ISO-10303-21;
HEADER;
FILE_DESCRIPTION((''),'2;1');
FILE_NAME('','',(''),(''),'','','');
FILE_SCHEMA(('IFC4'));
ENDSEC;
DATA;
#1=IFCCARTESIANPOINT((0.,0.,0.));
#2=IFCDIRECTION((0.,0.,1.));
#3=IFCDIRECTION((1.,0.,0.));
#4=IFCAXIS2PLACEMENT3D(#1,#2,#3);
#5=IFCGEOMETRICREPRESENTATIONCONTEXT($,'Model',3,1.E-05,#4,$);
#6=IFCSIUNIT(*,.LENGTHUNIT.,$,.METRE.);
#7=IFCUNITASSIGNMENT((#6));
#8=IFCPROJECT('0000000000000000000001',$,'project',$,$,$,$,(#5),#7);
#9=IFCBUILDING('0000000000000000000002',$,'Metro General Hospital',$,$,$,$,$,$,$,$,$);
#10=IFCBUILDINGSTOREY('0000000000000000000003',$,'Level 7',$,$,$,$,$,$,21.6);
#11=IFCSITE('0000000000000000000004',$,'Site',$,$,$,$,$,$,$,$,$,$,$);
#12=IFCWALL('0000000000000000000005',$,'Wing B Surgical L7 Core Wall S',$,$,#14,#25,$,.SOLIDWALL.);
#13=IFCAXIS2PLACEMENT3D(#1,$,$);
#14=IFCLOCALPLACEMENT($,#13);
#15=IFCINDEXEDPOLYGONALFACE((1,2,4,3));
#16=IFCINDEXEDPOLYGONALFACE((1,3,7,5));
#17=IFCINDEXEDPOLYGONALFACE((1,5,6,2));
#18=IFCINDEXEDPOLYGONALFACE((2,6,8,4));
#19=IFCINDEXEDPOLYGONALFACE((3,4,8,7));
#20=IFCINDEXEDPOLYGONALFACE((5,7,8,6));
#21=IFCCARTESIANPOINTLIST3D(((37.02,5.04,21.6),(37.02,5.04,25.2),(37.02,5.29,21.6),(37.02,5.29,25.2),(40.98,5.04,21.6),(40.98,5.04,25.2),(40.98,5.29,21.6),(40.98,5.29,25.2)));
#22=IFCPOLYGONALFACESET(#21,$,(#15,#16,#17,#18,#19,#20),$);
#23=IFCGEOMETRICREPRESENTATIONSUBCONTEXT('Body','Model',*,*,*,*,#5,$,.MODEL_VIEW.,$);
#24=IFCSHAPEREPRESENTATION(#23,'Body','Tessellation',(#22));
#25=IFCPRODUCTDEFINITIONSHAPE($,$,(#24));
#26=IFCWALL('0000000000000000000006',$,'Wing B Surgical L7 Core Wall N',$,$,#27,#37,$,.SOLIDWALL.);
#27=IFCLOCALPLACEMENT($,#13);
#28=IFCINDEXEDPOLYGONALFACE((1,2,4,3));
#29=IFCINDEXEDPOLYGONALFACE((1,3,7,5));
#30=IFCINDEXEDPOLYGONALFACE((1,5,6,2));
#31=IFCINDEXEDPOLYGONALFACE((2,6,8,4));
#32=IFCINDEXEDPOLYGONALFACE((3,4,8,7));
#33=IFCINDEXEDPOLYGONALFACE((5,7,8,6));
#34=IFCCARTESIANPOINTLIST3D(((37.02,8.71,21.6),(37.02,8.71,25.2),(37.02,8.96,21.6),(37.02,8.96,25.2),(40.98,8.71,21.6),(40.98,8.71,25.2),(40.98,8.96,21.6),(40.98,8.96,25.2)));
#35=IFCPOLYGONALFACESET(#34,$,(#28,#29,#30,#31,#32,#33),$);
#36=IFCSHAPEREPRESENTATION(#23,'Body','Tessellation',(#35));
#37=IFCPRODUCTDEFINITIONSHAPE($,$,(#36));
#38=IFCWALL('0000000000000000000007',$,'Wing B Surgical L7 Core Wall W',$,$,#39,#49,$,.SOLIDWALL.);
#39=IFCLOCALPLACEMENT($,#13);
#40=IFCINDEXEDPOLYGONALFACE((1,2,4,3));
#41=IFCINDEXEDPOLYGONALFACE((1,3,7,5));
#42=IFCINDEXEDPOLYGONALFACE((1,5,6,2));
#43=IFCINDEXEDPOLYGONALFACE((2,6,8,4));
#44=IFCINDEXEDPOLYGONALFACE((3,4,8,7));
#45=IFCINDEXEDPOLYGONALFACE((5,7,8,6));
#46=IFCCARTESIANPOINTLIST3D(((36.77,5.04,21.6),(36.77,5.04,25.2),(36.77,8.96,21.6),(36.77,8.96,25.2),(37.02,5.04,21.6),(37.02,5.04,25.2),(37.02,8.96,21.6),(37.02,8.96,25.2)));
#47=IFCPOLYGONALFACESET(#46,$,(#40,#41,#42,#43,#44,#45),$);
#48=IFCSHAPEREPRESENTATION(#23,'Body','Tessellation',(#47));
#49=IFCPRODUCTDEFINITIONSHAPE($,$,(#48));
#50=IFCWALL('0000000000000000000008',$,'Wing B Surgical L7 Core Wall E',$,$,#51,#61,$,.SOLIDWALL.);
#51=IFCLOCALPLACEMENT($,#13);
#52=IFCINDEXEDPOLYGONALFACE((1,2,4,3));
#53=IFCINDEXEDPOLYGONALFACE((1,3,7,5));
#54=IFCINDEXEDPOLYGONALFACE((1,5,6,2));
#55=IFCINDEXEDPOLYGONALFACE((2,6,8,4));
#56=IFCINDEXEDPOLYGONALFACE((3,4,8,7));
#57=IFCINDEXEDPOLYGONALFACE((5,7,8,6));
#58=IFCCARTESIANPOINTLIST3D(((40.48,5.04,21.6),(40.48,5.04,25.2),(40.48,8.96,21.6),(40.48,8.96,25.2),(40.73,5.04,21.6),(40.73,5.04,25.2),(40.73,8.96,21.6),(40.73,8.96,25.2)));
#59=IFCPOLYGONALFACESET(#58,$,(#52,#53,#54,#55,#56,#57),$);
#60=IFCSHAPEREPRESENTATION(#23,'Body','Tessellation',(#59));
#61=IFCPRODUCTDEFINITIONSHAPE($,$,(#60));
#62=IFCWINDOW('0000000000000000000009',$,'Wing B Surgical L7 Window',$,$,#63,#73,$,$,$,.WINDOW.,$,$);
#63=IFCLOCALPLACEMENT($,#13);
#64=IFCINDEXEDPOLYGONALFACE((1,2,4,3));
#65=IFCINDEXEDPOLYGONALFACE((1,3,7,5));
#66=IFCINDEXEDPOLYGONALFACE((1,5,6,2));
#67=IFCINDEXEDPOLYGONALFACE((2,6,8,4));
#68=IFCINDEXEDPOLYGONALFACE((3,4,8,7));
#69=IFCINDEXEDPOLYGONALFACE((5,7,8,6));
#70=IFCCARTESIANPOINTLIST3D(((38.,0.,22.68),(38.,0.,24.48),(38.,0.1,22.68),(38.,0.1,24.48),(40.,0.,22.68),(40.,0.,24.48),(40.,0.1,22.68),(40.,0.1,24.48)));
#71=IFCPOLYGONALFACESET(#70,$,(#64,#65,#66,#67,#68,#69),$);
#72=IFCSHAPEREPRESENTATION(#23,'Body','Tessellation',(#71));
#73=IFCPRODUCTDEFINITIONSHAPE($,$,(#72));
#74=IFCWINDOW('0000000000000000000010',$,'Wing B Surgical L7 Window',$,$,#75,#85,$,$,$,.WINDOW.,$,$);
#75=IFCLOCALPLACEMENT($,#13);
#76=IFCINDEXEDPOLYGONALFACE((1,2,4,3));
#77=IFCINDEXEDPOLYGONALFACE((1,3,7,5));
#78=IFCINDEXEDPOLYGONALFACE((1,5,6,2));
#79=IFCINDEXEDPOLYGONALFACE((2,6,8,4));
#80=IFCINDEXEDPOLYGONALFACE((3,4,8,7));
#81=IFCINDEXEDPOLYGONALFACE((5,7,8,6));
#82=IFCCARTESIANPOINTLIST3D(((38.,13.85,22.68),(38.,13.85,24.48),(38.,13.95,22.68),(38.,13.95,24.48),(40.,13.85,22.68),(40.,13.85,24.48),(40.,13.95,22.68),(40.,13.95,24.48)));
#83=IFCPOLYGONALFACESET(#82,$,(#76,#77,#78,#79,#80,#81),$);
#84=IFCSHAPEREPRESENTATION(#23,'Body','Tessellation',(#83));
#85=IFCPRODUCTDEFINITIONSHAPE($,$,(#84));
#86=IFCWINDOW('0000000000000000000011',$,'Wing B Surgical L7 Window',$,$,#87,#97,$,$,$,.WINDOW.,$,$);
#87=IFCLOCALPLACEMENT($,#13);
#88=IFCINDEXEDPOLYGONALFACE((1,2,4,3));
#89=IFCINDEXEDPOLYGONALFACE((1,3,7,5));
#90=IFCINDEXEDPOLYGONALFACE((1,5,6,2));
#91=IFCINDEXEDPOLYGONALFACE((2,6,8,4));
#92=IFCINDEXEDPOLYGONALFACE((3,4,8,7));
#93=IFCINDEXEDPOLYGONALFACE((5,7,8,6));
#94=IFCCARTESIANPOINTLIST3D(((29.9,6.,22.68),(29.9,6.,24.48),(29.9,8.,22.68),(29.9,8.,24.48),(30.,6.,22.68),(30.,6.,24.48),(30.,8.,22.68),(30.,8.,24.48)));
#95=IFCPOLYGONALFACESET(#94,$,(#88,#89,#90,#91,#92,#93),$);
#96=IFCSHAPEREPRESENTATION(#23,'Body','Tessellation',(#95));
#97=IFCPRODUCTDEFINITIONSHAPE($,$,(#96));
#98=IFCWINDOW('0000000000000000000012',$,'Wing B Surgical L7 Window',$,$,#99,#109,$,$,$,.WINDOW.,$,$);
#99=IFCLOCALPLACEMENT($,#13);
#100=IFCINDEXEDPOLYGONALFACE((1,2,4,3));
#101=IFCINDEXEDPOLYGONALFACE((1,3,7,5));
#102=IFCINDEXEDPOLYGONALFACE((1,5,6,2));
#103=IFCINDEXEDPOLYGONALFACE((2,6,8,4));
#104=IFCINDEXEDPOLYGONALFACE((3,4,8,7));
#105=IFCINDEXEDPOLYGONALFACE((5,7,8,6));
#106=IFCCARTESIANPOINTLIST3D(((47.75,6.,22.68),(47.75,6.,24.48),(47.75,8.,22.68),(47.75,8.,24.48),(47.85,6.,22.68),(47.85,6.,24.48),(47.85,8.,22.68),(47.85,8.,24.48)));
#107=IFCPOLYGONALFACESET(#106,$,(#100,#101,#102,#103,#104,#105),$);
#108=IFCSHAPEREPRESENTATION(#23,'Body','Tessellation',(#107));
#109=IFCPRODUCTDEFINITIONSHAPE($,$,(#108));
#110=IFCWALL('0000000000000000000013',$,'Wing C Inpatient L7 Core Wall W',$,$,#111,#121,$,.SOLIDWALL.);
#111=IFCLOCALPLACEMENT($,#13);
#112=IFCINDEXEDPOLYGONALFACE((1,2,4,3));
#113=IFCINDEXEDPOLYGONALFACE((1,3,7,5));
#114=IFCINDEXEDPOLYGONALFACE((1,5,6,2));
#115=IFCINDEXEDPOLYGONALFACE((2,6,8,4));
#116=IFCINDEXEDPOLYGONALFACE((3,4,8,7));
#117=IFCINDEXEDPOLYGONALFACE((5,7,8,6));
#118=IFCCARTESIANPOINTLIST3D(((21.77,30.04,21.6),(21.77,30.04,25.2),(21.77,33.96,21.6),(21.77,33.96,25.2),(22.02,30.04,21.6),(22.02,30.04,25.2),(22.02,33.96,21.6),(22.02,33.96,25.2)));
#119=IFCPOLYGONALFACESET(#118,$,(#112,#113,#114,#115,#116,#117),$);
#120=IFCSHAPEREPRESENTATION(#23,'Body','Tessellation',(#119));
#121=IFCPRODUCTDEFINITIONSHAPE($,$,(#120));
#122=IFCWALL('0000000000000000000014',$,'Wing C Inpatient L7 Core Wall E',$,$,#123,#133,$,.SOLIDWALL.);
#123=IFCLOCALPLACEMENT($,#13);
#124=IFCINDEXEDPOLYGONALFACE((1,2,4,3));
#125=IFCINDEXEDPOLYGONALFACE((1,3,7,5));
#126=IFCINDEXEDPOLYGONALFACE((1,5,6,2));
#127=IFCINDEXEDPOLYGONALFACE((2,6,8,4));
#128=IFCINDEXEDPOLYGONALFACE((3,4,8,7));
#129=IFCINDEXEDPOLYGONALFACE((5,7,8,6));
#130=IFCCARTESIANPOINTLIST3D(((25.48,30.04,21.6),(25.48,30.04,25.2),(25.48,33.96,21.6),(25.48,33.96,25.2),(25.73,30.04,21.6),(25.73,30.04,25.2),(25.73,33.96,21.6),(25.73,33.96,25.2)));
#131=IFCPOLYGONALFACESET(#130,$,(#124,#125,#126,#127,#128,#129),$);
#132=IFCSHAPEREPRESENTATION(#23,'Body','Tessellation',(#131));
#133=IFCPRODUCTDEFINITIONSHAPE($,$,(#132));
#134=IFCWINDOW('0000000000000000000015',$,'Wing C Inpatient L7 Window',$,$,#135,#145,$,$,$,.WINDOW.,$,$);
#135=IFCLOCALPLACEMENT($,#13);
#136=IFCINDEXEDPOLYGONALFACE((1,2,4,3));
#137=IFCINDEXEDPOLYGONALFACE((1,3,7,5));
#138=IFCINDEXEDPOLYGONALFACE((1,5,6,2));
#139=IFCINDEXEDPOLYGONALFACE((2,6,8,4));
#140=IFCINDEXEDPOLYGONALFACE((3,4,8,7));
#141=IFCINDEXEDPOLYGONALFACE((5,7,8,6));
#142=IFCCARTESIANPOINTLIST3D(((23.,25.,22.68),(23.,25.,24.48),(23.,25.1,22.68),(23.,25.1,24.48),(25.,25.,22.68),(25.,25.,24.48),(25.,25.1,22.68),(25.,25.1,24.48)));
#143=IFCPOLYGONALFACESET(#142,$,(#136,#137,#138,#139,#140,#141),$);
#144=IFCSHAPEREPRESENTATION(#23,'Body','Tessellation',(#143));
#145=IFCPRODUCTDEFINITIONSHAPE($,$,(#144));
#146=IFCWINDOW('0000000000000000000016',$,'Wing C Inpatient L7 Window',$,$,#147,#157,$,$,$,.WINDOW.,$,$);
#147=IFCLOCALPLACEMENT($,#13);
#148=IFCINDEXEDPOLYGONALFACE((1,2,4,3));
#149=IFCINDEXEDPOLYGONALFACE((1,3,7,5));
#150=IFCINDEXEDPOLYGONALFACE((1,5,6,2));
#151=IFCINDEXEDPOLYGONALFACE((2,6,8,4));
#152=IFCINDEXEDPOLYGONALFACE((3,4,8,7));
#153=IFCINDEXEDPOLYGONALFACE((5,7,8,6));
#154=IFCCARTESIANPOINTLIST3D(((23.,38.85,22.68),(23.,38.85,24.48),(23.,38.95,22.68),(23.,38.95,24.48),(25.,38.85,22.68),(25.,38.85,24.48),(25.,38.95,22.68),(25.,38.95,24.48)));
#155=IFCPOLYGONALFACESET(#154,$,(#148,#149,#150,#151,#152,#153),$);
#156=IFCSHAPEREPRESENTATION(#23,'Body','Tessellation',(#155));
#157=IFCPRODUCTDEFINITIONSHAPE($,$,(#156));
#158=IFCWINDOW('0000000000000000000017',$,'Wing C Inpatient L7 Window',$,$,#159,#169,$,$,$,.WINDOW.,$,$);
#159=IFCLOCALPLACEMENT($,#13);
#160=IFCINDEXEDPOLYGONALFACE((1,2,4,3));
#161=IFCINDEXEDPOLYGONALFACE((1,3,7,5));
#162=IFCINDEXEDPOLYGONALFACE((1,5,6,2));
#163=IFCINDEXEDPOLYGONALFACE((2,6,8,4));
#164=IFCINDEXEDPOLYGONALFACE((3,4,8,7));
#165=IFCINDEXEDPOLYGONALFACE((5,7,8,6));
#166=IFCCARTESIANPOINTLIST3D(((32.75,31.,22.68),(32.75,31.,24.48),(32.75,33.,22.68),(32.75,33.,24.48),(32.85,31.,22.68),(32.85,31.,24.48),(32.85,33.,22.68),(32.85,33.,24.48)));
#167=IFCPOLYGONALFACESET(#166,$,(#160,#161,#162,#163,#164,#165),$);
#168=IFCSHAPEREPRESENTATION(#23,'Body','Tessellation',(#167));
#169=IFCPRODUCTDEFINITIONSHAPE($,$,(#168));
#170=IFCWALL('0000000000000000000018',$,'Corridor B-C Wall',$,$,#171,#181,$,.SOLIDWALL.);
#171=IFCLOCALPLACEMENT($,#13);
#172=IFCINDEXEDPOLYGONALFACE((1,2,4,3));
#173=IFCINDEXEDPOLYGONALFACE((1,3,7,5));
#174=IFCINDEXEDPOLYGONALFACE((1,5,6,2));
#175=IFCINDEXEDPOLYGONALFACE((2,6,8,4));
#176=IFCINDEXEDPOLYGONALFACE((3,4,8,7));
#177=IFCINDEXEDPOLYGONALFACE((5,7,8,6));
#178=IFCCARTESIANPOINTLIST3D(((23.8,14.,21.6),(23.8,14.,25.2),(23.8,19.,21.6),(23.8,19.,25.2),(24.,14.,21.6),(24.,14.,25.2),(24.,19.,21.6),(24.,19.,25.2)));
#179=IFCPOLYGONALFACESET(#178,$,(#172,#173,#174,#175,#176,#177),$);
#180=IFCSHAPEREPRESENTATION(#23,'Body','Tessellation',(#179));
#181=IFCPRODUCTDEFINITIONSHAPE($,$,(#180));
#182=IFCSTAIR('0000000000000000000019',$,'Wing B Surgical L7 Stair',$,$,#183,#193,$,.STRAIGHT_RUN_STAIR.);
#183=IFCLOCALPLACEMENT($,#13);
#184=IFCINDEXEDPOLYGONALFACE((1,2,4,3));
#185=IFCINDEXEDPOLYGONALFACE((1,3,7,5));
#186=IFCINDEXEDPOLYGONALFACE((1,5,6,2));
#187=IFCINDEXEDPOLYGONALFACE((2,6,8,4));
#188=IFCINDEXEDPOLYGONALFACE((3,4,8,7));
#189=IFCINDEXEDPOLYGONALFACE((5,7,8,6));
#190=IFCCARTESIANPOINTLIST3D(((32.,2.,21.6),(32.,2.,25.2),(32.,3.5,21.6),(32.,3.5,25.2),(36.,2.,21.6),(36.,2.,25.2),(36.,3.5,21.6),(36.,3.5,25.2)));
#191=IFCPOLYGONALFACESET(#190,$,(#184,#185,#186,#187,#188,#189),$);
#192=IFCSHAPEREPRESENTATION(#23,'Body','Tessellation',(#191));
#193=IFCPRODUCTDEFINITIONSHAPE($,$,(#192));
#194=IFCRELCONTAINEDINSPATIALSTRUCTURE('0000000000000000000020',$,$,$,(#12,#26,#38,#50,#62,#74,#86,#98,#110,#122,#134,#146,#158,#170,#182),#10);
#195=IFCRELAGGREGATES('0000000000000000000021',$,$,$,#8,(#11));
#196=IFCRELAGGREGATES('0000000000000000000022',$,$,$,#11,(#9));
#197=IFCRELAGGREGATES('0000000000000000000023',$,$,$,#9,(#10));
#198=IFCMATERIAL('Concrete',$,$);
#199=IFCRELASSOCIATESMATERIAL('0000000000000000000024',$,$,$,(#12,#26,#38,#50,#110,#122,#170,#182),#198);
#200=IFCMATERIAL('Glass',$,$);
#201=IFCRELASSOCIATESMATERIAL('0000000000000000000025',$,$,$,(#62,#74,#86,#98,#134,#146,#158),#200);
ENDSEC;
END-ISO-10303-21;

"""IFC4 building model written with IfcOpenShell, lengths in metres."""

from ifc_helpers import new_model, si_unit, frame, origin_with_axes, place, context, subcontext, project, spatial, line, indexed_curve, outline, extrude, material, element, save


model = new_model("IFC4")

# Units and contexts
model_context = context("Model", 3, precision=1e-05, world=origin_with_axes())
body_context = subcontext(model_context, "Body", "Model", "MODEL_VIEW")
ifc_project = project(units=[si_unit("LENGTHUNIT", "METRE")], contexts=[model_context])

# Site, building, storey
site = spatial("IfcSite", under=ifc_project, Name="Site")
building = spatial("IfcBuilding", under=site, Name="Metro General Hospital")
storey = spatial("IfcBuildingStorey", under=building, Name="Level 7", Elevation=21.6)

# Shared definitions
ifc_material_1 = material(Name="Concrete")

# Walls
for number, where, z_axis, x_axis, name in (
    (1, (37.02, 5.04, 21.6), (0.0, 0.0, 1.0), (1.0, 0.0, 0.0), "Wing B Surgical L7 Core Wall S"),
    (2, (37.02, 8.71, 21.6), (0.0, 0.0, 1.0), (1.0, 0.0, 0.0), "Wing B Surgical L7 Core Wall N"),
):
    element("IfcWall", number, at=place(None, frame(where, z_axis=z_axis, x_axis=x_axis)), inside=storey, material=ifc_material_1, Name=name, PredefinedType="SOLIDWALL", context=body_context, shape_type="SweptSolid", body=[
        extrude(outline(indexed_curve([(0.0, 0.0), (3.96, 0.0), (3.96, 0.25), (0.0, 0.25)], segments=[line(1, 2, 3, 4, 1)])), origin_with_axes(), (0.0, 0.0, 1.0), 3.6),
    ])
for number, where, z_axis, x_axis, name in (
    (3, (37.02, 5.04, 21.6), (0.0, 0.0, 1.0), (0.0, 1.0, 0.0), "Wing B Surgical L7 Core Wall W"),
    (4, (40.73, 5.04, 21.6), (0.0, 0.0, 1.0), (0.0, 1.0, 0.0), "Wing B Surgical L7 Core Wall E"),
):
    element("IfcWall", number, at=place(None, frame(where, z_axis=z_axis, x_axis=x_axis)), inside=storey, material=ifc_material_1, Name=name, PredefinedType="SOLIDWALL", context=body_context, shape_type="SweptSolid", body=[
        extrude(outline(indexed_curve([(0.0, 0.0), (3.92, 0.0), (3.92, 0.25), (0.0, 0.25)], segments=[line(1, 2, 3, 4, 1)])), origin_with_axes(), (0.0, 0.0, 1.0), 3.6),
    ])

# Windows
ifc_material_2 = material(Name="Glass")
for number, where, z_axis, x_axis, name in (
    (5, (38.0, 0.0, 22.68), (0.0, 0.0, 1.0), (1.0, 0.0, 0.0), "Wing B Surgical L7 Window"),
    (6, (38.0, 13.85, 22.68), (0.0, 0.0, 1.0), (1.0, 0.0, 0.0), "Wing B Surgical L7 Window"),
    (7, (30.0, 6.0, 22.68), (0.0, 0.0, 1.0), (0.0, 1.0, 0.0), "Wing B Surgical L7 Window"),
    (8, (47.85, 6.0, 22.68), (0.0, 0.0, 1.0), (0.0, 1.0, 0.0), "Wing B Surgical L7 Window"),
):
    element("IfcWindow", number, at=place(None, frame(where, z_axis=z_axis, x_axis=x_axis)), inside=storey, material=ifc_material_2, Name=name, PredefinedType="WINDOW", context=body_context, shape_type="SweptSolid", body=[
        extrude(outline(indexed_curve([(0.0, 0.0), (2.0, 0.0), (2.0, 0.1), (0.0, 0.1)], segments=[line(1, 2, 3, 4, 1)])), origin_with_axes(), (0.0, 0.0, 1.0), 1.8),
    ])

# Walls
for number, where, z_axis, x_axis, name in (
    (9, (22.02, 30.04, 21.6), (0.0, 0.0, 1.0), (0.0, 1.0, 0.0), "Wing C Inpatient L7 Core Wall W"),
    (10, (25.73, 30.04, 21.6), (0.0, 0.0, 1.0), (0.0, 1.0, 0.0), "Wing C Inpatient L7 Core Wall E"),
):
    element("IfcWall", number, at=place(None, frame(where, z_axis=z_axis, x_axis=x_axis)), inside=storey, material=ifc_material_1, Name=name, PredefinedType="SOLIDWALL", context=body_context, shape_type="SweptSolid", body=[
        extrude(outline(indexed_curve([(0.0, 0.0), (3.92, 0.0), (3.92, 0.25), (0.0, 0.25)], segments=[line(1, 2, 3, 4, 1)])), origin_with_axes(), (0.0, 0.0, 1.0), 3.6),
    ])

# Windows
for number, where, z_axis, x_axis, name in (
    (11, (23.0, 25.0, 22.68), (0.0, 0.0, 1.0), (1.0, 0.0, 0.0), "Wing C Inpatient L7 Window"),
    (12, (23.0, 38.85, 22.68), (0.0, 0.0, 1.0), (1.0, 0.0, 0.0), "Wing C Inpatient L7 Window"),
    (13, (32.85, 31.0, 22.68), (0.0, 0.0, 1.0), (0.0, 1.0, 0.0), "Wing C Inpatient L7 Window"),
):
    element("IfcWindow", number, at=place(None, frame(where, z_axis=z_axis, x_axis=x_axis)), inside=storey, material=ifc_material_2, Name=name, PredefinedType="WINDOW", context=body_context, shape_type="SweptSolid", body=[
        extrude(outline(indexed_curve([(0.0, 0.0), (2.0, 0.0), (2.0, 0.1), (0.0, 0.1)], segments=[line(1, 2, 3, 4, 1)])), origin_with_axes(), (0.0, 0.0, 1.0), 1.8),
    ])

# Wall
wall_placement = place(None, frame((24.0, 14.0, 21.6), z_axis=(0.0, 0.0, 1.0), x_axis=(0.0, 1.0, 0.0)))
element("IfcWall", 14, at=wall_placement, inside=storey, material=ifc_material_1, Name="Corridor B-C Wall", PredefinedType="SOLIDWALL", context=body_context, shape_type="SweptSolid", body=[
    extrude(outline(indexed_curve([(0.0, 0.0), (5.0, 0.0), (5.0, 0.2), (0.0, 0.2)], segments=[line(1, 2, 3, 4, 1)])), origin_with_axes(), (0.0, 0.0, 1.0), 3.6),
])

# Stair
stair_placement = place(None, frame((32.0, 2.0, 21.6), z_axis=(0.0, 0.0, 1.0), x_axis=(1.0, 0.0, 0.0)))
element("IfcStair", 15, at=stair_placement, inside=storey, material=ifc_material_1, Name="Wing B Surgical L7 Stair", PredefinedType="STRAIGHT_RUN_STAIR", context=body_context, shape_type="SweptSolid", body=[
    extrude(outline(indexed_curve([(0.0, 0.0), (4.0, 0.0), (4.0, 1.5), (0.0, 1.5)], segments=[line(1, 2, 3, 4, 1)])), origin_with_axes(), (0.0, 0.0, 1.0), 3.6),
])

save(model, "model.ifc")
